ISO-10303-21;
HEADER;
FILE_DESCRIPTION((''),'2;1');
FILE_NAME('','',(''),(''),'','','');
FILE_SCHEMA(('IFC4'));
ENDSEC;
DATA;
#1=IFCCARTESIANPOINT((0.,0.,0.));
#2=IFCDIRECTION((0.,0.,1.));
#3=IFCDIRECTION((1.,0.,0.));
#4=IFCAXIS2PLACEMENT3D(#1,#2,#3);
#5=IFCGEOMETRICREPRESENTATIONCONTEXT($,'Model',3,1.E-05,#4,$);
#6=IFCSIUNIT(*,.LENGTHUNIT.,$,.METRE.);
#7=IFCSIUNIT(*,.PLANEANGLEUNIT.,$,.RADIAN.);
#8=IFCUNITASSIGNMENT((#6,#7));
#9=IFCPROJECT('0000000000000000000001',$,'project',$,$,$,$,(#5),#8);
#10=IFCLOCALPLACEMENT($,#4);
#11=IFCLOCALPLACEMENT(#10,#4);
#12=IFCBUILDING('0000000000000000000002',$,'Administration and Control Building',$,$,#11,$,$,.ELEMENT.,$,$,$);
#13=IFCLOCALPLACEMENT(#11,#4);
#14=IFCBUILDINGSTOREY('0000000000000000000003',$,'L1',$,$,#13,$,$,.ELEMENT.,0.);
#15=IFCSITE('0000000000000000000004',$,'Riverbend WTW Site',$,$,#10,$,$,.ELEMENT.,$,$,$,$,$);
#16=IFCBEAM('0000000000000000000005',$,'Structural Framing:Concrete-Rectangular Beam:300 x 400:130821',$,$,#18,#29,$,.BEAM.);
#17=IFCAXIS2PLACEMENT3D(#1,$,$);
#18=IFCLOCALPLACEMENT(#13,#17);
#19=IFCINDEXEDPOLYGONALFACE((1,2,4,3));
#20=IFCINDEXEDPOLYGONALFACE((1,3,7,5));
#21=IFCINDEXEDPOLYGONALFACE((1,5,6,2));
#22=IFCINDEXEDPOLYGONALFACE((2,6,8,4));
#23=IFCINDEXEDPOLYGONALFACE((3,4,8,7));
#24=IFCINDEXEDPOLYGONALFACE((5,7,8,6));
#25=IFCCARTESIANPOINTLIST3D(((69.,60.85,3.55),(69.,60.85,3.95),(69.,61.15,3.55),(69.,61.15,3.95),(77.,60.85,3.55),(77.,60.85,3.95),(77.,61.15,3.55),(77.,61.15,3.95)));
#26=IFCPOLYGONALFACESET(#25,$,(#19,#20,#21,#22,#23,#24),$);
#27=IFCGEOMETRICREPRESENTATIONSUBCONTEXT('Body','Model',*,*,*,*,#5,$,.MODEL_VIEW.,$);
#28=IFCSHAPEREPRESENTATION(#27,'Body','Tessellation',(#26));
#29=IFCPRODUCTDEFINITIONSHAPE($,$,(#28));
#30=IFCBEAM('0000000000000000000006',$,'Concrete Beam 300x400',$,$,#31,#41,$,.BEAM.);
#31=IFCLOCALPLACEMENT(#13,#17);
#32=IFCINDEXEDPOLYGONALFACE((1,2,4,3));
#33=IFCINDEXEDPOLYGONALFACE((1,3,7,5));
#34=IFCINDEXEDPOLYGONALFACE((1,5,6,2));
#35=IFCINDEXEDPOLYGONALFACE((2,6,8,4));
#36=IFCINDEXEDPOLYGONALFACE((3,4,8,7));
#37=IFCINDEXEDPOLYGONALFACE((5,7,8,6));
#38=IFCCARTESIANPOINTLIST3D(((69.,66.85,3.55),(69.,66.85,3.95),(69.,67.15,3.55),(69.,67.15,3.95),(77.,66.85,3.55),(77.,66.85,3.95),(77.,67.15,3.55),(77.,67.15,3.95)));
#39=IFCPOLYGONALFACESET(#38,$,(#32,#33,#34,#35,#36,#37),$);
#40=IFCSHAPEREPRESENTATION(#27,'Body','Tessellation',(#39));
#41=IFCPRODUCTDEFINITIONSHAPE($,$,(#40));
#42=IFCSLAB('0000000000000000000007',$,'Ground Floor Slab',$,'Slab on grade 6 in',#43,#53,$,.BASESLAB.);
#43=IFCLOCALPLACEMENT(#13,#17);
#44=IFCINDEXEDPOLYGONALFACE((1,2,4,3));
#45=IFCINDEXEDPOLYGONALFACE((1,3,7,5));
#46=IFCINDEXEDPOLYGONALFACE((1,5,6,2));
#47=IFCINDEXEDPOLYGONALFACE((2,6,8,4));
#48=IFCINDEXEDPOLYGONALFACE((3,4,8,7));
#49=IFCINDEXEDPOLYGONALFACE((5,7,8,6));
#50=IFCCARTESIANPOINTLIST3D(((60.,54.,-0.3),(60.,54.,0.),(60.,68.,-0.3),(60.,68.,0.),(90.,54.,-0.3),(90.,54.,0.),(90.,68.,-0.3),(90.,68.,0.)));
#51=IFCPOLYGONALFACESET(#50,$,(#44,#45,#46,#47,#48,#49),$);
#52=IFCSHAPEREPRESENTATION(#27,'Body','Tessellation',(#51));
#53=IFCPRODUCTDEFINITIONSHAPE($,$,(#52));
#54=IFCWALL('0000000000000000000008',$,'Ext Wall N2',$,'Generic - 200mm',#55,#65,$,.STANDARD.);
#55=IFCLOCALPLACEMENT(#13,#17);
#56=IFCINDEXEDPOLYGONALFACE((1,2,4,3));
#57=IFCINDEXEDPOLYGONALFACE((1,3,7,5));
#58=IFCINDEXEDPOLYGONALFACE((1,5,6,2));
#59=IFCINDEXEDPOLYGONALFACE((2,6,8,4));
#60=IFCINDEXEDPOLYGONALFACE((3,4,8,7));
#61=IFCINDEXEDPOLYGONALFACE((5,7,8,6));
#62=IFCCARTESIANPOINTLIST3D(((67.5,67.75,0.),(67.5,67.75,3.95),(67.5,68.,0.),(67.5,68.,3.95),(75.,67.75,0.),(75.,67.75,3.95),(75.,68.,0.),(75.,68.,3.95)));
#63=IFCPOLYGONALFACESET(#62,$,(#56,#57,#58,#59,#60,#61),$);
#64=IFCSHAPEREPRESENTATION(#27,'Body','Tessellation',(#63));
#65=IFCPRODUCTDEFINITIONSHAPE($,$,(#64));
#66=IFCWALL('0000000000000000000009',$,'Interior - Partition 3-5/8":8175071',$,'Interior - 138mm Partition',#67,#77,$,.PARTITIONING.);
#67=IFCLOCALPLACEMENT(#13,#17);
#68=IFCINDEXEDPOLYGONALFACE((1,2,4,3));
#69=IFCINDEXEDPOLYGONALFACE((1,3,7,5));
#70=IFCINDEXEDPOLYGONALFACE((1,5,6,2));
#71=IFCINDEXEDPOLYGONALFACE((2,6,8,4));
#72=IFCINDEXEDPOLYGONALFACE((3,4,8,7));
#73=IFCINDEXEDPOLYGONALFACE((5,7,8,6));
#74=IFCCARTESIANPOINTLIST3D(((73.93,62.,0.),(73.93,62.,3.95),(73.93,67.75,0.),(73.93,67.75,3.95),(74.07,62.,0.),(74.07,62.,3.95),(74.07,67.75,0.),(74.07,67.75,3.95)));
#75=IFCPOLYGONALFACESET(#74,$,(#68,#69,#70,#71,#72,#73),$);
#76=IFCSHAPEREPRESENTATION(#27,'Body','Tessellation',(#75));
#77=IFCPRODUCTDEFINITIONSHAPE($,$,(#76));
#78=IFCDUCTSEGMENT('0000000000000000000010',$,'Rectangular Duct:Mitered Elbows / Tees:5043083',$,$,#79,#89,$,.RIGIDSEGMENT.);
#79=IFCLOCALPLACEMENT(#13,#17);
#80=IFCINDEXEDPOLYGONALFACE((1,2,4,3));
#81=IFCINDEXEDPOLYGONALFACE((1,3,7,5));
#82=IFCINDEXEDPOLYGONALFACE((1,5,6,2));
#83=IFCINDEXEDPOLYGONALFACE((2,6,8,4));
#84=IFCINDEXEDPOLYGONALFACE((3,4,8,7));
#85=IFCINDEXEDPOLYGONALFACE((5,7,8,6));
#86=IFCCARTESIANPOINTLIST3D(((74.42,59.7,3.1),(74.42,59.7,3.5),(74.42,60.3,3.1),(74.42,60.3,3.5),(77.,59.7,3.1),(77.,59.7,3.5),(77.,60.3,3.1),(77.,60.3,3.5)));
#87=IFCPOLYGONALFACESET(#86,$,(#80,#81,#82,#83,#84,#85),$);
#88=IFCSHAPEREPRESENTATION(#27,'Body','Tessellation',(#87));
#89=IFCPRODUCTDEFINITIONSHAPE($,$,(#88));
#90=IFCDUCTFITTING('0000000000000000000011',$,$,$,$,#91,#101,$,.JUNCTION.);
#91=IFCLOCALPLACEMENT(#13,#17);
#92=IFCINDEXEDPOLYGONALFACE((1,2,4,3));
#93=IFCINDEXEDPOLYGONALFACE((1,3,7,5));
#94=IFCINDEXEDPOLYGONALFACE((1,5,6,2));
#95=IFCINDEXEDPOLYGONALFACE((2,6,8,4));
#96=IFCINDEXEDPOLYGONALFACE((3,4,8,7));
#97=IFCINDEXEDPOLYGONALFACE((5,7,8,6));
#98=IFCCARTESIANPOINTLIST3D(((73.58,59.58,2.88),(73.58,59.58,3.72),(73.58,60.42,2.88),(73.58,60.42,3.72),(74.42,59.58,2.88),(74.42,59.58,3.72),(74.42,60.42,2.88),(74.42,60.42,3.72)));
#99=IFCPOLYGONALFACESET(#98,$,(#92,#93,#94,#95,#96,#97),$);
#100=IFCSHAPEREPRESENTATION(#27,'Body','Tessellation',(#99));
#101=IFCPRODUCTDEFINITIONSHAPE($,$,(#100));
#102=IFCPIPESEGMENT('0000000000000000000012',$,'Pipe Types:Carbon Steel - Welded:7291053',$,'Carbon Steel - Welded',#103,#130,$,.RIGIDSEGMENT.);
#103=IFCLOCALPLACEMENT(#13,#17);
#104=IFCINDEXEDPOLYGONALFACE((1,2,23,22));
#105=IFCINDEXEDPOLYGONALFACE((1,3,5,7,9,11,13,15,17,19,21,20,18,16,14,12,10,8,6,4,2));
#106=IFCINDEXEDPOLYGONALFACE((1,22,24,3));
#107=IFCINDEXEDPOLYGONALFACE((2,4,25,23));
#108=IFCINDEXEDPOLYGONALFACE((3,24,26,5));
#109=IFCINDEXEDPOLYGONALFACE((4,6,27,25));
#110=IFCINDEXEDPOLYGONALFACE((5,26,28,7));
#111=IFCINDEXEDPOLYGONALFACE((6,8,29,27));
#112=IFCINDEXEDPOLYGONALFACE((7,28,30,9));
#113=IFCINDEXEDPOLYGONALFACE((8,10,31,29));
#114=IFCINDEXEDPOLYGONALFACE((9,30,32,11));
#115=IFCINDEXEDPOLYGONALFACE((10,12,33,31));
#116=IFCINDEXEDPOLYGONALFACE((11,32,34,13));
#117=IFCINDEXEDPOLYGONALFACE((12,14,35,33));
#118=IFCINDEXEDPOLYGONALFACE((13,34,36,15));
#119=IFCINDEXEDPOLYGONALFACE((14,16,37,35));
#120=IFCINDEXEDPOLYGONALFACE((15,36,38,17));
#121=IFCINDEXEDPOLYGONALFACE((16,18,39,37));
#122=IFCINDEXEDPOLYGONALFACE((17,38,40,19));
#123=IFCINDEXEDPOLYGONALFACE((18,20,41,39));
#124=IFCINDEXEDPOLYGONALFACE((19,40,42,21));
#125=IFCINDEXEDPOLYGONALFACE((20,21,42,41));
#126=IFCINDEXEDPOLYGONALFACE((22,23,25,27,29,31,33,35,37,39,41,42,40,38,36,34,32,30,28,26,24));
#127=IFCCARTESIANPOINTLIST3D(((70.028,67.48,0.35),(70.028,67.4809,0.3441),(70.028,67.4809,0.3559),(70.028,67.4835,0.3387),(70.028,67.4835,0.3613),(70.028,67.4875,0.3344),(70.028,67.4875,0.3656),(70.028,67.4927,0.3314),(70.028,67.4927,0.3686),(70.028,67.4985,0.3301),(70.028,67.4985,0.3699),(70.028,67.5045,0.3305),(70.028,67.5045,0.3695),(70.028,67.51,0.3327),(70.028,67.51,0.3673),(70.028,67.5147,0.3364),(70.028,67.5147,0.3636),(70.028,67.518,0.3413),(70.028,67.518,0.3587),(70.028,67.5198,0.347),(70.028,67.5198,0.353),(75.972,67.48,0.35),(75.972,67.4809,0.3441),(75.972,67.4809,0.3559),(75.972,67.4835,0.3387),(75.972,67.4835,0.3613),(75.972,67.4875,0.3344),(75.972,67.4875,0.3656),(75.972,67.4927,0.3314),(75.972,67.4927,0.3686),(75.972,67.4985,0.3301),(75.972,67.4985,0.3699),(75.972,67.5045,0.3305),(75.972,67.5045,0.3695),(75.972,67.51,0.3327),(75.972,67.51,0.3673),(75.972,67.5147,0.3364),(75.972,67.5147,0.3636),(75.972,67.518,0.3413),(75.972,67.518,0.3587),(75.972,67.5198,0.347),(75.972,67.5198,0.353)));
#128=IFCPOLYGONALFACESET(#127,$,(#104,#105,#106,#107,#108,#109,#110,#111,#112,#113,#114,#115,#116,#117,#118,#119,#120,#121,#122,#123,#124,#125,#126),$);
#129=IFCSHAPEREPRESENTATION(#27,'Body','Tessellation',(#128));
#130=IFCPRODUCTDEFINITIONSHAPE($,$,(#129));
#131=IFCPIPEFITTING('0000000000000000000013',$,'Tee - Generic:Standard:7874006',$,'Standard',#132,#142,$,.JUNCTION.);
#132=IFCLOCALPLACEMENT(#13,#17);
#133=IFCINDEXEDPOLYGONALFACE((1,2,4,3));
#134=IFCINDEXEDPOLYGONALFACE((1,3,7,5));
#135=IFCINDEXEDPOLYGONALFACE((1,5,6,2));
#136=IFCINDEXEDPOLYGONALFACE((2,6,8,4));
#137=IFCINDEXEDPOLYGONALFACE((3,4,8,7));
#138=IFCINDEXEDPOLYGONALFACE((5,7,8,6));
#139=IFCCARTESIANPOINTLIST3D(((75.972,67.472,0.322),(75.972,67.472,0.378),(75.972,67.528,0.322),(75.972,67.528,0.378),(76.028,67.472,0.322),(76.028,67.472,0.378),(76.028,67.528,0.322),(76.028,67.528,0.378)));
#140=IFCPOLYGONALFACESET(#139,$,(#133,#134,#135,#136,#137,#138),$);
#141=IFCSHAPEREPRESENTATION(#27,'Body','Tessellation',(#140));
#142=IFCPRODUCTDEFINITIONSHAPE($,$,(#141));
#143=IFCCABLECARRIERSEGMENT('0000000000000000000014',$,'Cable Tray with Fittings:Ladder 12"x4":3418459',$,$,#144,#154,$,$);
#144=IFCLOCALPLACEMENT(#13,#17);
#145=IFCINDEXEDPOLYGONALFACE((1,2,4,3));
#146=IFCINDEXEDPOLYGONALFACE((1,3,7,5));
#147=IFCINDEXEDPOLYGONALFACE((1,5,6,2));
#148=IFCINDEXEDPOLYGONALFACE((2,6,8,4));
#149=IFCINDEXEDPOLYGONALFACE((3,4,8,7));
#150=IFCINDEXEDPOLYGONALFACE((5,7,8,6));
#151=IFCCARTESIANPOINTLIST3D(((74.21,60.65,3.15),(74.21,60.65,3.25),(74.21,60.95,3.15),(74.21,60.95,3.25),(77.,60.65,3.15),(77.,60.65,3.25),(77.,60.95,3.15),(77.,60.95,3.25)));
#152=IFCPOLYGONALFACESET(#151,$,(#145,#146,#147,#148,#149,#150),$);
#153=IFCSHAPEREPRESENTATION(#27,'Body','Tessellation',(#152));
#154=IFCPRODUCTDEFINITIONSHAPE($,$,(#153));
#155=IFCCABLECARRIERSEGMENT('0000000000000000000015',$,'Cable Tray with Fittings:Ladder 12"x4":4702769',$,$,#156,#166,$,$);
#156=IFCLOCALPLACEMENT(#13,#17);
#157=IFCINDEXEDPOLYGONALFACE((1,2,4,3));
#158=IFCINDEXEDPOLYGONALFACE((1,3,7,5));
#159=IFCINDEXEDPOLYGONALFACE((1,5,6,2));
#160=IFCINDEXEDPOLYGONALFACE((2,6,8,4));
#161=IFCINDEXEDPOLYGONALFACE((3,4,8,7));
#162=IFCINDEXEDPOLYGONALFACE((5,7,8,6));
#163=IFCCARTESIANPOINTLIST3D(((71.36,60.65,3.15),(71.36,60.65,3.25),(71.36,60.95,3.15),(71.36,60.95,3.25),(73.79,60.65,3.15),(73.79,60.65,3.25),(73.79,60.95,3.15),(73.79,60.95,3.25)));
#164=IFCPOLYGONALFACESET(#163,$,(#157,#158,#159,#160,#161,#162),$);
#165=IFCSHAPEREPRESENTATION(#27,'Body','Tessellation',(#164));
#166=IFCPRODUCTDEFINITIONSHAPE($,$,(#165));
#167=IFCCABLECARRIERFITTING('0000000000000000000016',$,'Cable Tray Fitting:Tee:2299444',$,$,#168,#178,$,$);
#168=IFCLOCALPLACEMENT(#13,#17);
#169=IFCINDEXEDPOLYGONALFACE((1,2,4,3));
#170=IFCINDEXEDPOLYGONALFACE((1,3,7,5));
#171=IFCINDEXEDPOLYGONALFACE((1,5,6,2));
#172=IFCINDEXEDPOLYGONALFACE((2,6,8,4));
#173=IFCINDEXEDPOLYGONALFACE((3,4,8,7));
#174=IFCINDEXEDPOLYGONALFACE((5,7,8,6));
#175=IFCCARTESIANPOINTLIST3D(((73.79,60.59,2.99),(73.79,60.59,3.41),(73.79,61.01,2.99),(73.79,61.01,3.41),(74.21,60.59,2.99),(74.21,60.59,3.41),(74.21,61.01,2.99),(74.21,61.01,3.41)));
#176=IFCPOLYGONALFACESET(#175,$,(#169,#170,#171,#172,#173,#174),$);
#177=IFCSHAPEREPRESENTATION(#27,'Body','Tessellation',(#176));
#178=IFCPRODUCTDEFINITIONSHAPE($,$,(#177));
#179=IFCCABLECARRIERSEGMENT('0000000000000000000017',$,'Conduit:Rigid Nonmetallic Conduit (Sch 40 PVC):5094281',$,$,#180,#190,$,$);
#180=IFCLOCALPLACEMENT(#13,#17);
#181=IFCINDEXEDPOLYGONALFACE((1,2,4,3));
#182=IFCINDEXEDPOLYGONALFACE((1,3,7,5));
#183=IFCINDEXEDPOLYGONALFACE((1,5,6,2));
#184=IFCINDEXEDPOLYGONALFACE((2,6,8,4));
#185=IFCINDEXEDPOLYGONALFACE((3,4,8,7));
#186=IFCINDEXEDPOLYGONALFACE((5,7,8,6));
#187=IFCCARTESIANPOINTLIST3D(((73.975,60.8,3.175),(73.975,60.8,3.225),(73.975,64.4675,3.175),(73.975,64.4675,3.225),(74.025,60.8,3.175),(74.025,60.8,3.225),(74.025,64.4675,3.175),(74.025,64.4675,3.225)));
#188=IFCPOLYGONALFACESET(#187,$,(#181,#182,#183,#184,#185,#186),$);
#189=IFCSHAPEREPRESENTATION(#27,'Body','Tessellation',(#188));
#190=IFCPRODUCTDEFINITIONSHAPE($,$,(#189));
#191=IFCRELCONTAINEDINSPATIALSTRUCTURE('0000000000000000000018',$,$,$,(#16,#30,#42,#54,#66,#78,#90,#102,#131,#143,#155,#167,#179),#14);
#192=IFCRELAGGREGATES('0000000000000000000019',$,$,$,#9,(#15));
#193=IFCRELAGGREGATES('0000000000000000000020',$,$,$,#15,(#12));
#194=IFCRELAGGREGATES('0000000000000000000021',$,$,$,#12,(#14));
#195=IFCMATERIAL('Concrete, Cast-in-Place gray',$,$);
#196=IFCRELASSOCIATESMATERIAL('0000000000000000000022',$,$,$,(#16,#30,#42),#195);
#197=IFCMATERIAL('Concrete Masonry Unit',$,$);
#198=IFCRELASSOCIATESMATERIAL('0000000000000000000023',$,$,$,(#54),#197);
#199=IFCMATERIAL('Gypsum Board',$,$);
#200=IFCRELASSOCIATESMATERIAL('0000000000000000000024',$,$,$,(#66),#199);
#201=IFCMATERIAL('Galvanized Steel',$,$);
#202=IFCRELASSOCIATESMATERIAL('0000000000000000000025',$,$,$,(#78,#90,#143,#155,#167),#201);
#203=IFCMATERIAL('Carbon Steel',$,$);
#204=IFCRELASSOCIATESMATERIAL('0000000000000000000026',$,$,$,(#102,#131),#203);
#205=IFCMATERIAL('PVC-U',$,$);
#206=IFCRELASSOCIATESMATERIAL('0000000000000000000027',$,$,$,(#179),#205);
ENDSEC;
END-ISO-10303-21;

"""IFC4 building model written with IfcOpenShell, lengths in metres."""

from ifc_helpers import new_model, si_unit, frame, origin_with_axes, origin_2d, place, context, subcontext, project, spatial, rectangle, circle, extrude, material, element, save


model = new_model("IFC4")

# Units and contexts
model_context = context("Model", 3, precision=1e-05, world=origin_with_axes())
body_context = subcontext(model_context, "Body", "Model", "MODEL_VIEW")
ifc_project = project(units=[si_unit("LENGTHUNIT", "METRE"), si_unit("PLANEANGLEUNIT", "RADIAN")], contexts=[model_context])

# Site, building, storey
site_placement = place(None, origin_with_axes())
site = spatial("IfcSite", under=ifc_project, at=site_placement, Name="Riverbend WTW Site", CompositionType="ELEMENT")
building_placement = place(site_placement, origin_with_axes())
building = spatial("IfcBuilding", under=site, at=building_placement, Name="Administration and Control Building", CompositionType="ELEMENT")
storey_placement = place(building_placement, origin_with_axes())
storey = spatial("IfcBuildingStorey", under=building, at=storey_placement, Name="L1", CompositionType="ELEMENT", Elevation=0.0)

# Beams
ifc_material_1 = material(Name="Concrete, Cast-in-Place gray")
for number, where, z_axis, x_axis, name in (
    (1, (73.0, 61.0, 3.75), (0.0, 0.0, 1.0), (1.0, 0.0, 0.0), "Structural Framing:Concrete-Rectangular Beam:300 x 400:130821"),
    (2, (73.0, 67.0, 3.75), (0.0, 0.0, 1.0), (1.0, 0.0, 0.0), "Concrete Beam 300x400"),
):
    element("IfcBeam", number, at=place(None, frame(where, z_axis=z_axis, x_axis=x_axis)), inside=storey, material=ifc_material_1, Name=name, PredefinedType="BEAM", context=body_context, shape_type="SweptSolid", body=[
        extrude(rectangle(XDim=8.0, YDim=0.3, at=origin_2d()), frame((0.0, 0.0, -0.2), z_axis=(0.0, 0.0, 1.0), x_axis=(1.0, 0.0, 0.0)), (0.0, 0.0, 1.0), 0.4),
    ])

# Slab
slab_placement = place(None, frame((75.0, 61.0, -0.15), z_axis=(0.0, 0.0, 1.0), x_axis=(1.0, 0.0, 0.0)))
element("IfcSlab", 3, at=slab_placement, inside=storey, material=ifc_material_1, Name="Ground Floor Slab", ObjectType="Slab on grade 6 in", PredefinedType="BASESLAB", context=body_context, shape_type="SweptSolid", body=[
    extrude(rectangle(XDim=30.0, YDim=14.0, at=origin_2d()), frame((0.0, 0.0, -0.15), z_axis=(0.0, 0.0, 1.0), x_axis=(1.0, 0.0, 0.0)), (0.0, 0.0, 1.0), 0.3),
])

# Walls
ifc_material_2 = material(Name="Concrete Masonry Unit")
wall_1_placement = place(None, frame((71.25, 67.875, 1.975), z_axis=(0.0, 0.0, 1.0), x_axis=(1.0, 0.0, 0.0)))
element("IfcWall", 4, at=wall_1_placement, inside=storey, material=ifc_material_2, Name="Ext Wall N2", ObjectType="Generic - 200mm", PredefinedType="STANDARD", context=body_context, shape_type="SweptSolid", body=[
    extrude(rectangle(XDim=7.5, YDim=0.25, at=origin_2d()), frame((0.0, 0.0, -1.975), z_axis=(0.0, 0.0, 1.0), x_axis=(1.0, 0.0, 0.0)), (0.0, 0.0, 1.0), 3.95),
])
ifc_material_3 = material(Name="Gypsum Board")
wall_2_placement = place(None, frame((74.0, 64.875, 1.975), z_axis=(0.0, 0.0, 1.0), x_axis=(1.0, 0.0, 0.0)))
element("IfcWall", 5, at=wall_2_placement, inside=storey, material=ifc_material_3, Name="Interior - Partition 3-5/8\":8175071", ObjectType="Interior - 138mm Partition", PredefinedType="PARTITIONING", context=body_context, shape_type="SweptSolid", body=[
    extrude(rectangle(XDim=0.14, YDim=5.75, at=origin_2d()), frame((0.0, 0.0, -1.975), z_axis=(0.0, 0.0, 1.0), x_axis=(1.0, 0.0, 0.0)), (0.0, 0.0, 1.0), 3.95),
])

# Duct segment
ifc_material_4 = material(Name="Galvanized Steel")
duct_segment_placement = place(None, frame((75.71, 60.0, 3.3), z_axis=(0.0, 0.0, 1.0), x_axis=(1.0, 0.0, 0.0)))
element("IfcDuctSegment", 6, at=duct_segment_placement, inside=storey, material=ifc_material_4, Name="Rectangular Duct:Mitered Elbows / Tees:5043083", PredefinedType="RIGIDSEGMENT", context=body_context, shape_type="SweptSolid", body=[
    extrude(rectangle(XDim=2.58, YDim=0.6, at=origin_2d()), frame((0.0, 0.0, -0.2), z_axis=(0.0, 0.0, 1.0), x_axis=(1.0, 0.0, 0.0)), (0.0, 0.0, 1.0), 0.4),
])

# Duct fitting
duct_fitting_placement = place(None, frame((74.0, 60.0, 3.3), z_axis=(0.0, 0.0, 1.0), x_axis=(1.0, 0.0, 0.0)))
element("IfcDuctFitting", 7, at=duct_fitting_placement, inside=storey, material=ifc_material_4, PredefinedType="JUNCTION", context=body_context, shape_type="SweptSolid", body=[
    extrude(rectangle(XDim=0.84, YDim=0.84, at=origin_2d()), frame((0.0, 0.0, -0.42), z_axis=(0.0, 0.0, 1.0), x_axis=(1.0, 0.0, 0.0)), (0.0, 0.0, 1.0), 0.84),
])

# Pipe segment
ifc_material_5 = material(Name="Carbon Steel")
pipe_segment_placement = place(None, frame((75.972, 67.5, 0.35), z_axis=(0.0, 0.0, 1.0), x_axis=(1.0, 0.0, 0.0)))
element("IfcPipeSegment", 8, at=pipe_segment_placement, inside=storey, material=ifc_material_5, Name="Pipe Types:Carbon Steel - Welded:7291053", ObjectType="Carbon Steel - Welded", PredefinedType="RIGIDSEGMENT", context=body_context, shape_type="SweptSolid", body=[
    extrude(circle(Radius=0.02, at=origin_2d()), frame((0.0, 0.0, 0.0), z_axis=(-1.0, 0.0, 0.0), x_axis=(0.0, -1.0, 0.0)), (0.0, 0.0, 1.0), 5.944),
])

# Pipe fitting
pipe_fitting_placement = place(None, frame((76.0, 67.5, 0.35), z_axis=(0.0, 0.0, 1.0), x_axis=(1.0, 0.0, 0.0)))
element("IfcPipeFitting", 9, at=pipe_fitting_placement, inside=storey, material=ifc_material_5, Name="Tee - Generic:Standard:7874006", ObjectType="Standard", PredefinedType="JUNCTION", context=body_context, shape_type="SweptSolid", body=[
    extrude(rectangle(XDim=0.056, YDim=0.056, at=origin_2d()), frame((0.0, 0.0, -0.028), z_axis=(0.0, 0.0, 1.0), x_axis=(1.0, 0.0, 0.0)), (0.0, 0.0, 1.0), 0.056),
])

# Cable carrier segments
cable_carrier_segment_1_placement = place(None, frame((75.605, 60.8, 3.2), z_axis=(0.0, 0.0, 1.0), x_axis=(1.0, 0.0, 0.0)))
element("IfcCableCarrierSegment", 10, at=cable_carrier_segment_1_placement, inside=storey, material=ifc_material_4, Name="Cable Tray with Fittings:Ladder 12\"x4\":3418459", context=body_context, shape_type="SweptSolid", body=[
    extrude(rectangle(XDim=2.79, YDim=0.3, at=origin_2d()), frame((0.0, 0.0, -0.05), z_axis=(0.0, 0.0, 1.0), x_axis=(1.0, 0.0, 0.0)), (0.0, 0.0, 1.0), 0.1),
])
cable_carrier_segment_2_placement = place(None, frame((72.575, 60.8, 3.2), z_axis=(0.0, 0.0, 1.0), x_axis=(1.0, 0.0, 0.0)))
element("IfcCableCarrierSegment", 11, at=cable_carrier_segment_2_placement, inside=storey, material=ifc_material_4, Name="Cable Tray with Fittings:Ladder 12\"x4\":4702769", context=body_context, shape_type="SweptSolid", body=[
    extrude(rectangle(XDim=2.43, YDim=0.3, at=origin_2d()), frame((0.0, 0.0, -0.05), z_axis=(0.0, 0.0, 1.0), x_axis=(1.0, 0.0, 0.0)), (0.0, 0.0, 1.0), 0.1),
])

# Cable carrier fitting
cable_carrier_fitting_1_placement = place(None, frame((74.0, 60.8, 3.2), z_axis=(0.0, 0.0, 1.0), x_axis=(1.0, 0.0, 0.0)))
element("IfcCableCarrierFitting", 12, at=cable_carrier_fitting_1_placement, inside=storey, material=ifc_material_4, Name="Cable Tray Fitting:Tee:2299444", context=body_context, shape_type="SweptSolid", body=[
    extrude(rectangle(XDim=0.42, YDim=0.42, at=origin_2d()), frame((0.0, 0.0, -0.21), z_axis=(0.0, 0.0, 1.0), x_axis=(1.0, 0.0, 0.0)), (0.0, 0.0, 1.0), 0.42),
])

# Cable carrier segment
ifc_material_6 = material(Name="PVC-U")
cable_carrier_segment_3_placement = place(None, frame((74.0, 62.6337, 3.2), z_axis=(0.0, 0.0, 1.0), x_axis=(1.0, 0.0, 0.0)))
element("IfcCableCarrierSegment", 13, at=cable_carrier_segment_3_placement, inside=storey, material=ifc_material_6, Name="Conduit:Rigid Nonmetallic Conduit (Sch 40 PVC):5094281", context=body_context, shape_type="SweptSolid", body=[
    extrude(rectangle(XDim=0.05, YDim=3.6675, at=origin_2d()), frame((0.0, 0.0, -0.025), z_axis=(0.0, 0.0, 1.0), x_axis=(1.0, 0.0, 0.0)), (0.0, 0.0, 1.0), 0.05),
])

save(model, "model.ifc")
